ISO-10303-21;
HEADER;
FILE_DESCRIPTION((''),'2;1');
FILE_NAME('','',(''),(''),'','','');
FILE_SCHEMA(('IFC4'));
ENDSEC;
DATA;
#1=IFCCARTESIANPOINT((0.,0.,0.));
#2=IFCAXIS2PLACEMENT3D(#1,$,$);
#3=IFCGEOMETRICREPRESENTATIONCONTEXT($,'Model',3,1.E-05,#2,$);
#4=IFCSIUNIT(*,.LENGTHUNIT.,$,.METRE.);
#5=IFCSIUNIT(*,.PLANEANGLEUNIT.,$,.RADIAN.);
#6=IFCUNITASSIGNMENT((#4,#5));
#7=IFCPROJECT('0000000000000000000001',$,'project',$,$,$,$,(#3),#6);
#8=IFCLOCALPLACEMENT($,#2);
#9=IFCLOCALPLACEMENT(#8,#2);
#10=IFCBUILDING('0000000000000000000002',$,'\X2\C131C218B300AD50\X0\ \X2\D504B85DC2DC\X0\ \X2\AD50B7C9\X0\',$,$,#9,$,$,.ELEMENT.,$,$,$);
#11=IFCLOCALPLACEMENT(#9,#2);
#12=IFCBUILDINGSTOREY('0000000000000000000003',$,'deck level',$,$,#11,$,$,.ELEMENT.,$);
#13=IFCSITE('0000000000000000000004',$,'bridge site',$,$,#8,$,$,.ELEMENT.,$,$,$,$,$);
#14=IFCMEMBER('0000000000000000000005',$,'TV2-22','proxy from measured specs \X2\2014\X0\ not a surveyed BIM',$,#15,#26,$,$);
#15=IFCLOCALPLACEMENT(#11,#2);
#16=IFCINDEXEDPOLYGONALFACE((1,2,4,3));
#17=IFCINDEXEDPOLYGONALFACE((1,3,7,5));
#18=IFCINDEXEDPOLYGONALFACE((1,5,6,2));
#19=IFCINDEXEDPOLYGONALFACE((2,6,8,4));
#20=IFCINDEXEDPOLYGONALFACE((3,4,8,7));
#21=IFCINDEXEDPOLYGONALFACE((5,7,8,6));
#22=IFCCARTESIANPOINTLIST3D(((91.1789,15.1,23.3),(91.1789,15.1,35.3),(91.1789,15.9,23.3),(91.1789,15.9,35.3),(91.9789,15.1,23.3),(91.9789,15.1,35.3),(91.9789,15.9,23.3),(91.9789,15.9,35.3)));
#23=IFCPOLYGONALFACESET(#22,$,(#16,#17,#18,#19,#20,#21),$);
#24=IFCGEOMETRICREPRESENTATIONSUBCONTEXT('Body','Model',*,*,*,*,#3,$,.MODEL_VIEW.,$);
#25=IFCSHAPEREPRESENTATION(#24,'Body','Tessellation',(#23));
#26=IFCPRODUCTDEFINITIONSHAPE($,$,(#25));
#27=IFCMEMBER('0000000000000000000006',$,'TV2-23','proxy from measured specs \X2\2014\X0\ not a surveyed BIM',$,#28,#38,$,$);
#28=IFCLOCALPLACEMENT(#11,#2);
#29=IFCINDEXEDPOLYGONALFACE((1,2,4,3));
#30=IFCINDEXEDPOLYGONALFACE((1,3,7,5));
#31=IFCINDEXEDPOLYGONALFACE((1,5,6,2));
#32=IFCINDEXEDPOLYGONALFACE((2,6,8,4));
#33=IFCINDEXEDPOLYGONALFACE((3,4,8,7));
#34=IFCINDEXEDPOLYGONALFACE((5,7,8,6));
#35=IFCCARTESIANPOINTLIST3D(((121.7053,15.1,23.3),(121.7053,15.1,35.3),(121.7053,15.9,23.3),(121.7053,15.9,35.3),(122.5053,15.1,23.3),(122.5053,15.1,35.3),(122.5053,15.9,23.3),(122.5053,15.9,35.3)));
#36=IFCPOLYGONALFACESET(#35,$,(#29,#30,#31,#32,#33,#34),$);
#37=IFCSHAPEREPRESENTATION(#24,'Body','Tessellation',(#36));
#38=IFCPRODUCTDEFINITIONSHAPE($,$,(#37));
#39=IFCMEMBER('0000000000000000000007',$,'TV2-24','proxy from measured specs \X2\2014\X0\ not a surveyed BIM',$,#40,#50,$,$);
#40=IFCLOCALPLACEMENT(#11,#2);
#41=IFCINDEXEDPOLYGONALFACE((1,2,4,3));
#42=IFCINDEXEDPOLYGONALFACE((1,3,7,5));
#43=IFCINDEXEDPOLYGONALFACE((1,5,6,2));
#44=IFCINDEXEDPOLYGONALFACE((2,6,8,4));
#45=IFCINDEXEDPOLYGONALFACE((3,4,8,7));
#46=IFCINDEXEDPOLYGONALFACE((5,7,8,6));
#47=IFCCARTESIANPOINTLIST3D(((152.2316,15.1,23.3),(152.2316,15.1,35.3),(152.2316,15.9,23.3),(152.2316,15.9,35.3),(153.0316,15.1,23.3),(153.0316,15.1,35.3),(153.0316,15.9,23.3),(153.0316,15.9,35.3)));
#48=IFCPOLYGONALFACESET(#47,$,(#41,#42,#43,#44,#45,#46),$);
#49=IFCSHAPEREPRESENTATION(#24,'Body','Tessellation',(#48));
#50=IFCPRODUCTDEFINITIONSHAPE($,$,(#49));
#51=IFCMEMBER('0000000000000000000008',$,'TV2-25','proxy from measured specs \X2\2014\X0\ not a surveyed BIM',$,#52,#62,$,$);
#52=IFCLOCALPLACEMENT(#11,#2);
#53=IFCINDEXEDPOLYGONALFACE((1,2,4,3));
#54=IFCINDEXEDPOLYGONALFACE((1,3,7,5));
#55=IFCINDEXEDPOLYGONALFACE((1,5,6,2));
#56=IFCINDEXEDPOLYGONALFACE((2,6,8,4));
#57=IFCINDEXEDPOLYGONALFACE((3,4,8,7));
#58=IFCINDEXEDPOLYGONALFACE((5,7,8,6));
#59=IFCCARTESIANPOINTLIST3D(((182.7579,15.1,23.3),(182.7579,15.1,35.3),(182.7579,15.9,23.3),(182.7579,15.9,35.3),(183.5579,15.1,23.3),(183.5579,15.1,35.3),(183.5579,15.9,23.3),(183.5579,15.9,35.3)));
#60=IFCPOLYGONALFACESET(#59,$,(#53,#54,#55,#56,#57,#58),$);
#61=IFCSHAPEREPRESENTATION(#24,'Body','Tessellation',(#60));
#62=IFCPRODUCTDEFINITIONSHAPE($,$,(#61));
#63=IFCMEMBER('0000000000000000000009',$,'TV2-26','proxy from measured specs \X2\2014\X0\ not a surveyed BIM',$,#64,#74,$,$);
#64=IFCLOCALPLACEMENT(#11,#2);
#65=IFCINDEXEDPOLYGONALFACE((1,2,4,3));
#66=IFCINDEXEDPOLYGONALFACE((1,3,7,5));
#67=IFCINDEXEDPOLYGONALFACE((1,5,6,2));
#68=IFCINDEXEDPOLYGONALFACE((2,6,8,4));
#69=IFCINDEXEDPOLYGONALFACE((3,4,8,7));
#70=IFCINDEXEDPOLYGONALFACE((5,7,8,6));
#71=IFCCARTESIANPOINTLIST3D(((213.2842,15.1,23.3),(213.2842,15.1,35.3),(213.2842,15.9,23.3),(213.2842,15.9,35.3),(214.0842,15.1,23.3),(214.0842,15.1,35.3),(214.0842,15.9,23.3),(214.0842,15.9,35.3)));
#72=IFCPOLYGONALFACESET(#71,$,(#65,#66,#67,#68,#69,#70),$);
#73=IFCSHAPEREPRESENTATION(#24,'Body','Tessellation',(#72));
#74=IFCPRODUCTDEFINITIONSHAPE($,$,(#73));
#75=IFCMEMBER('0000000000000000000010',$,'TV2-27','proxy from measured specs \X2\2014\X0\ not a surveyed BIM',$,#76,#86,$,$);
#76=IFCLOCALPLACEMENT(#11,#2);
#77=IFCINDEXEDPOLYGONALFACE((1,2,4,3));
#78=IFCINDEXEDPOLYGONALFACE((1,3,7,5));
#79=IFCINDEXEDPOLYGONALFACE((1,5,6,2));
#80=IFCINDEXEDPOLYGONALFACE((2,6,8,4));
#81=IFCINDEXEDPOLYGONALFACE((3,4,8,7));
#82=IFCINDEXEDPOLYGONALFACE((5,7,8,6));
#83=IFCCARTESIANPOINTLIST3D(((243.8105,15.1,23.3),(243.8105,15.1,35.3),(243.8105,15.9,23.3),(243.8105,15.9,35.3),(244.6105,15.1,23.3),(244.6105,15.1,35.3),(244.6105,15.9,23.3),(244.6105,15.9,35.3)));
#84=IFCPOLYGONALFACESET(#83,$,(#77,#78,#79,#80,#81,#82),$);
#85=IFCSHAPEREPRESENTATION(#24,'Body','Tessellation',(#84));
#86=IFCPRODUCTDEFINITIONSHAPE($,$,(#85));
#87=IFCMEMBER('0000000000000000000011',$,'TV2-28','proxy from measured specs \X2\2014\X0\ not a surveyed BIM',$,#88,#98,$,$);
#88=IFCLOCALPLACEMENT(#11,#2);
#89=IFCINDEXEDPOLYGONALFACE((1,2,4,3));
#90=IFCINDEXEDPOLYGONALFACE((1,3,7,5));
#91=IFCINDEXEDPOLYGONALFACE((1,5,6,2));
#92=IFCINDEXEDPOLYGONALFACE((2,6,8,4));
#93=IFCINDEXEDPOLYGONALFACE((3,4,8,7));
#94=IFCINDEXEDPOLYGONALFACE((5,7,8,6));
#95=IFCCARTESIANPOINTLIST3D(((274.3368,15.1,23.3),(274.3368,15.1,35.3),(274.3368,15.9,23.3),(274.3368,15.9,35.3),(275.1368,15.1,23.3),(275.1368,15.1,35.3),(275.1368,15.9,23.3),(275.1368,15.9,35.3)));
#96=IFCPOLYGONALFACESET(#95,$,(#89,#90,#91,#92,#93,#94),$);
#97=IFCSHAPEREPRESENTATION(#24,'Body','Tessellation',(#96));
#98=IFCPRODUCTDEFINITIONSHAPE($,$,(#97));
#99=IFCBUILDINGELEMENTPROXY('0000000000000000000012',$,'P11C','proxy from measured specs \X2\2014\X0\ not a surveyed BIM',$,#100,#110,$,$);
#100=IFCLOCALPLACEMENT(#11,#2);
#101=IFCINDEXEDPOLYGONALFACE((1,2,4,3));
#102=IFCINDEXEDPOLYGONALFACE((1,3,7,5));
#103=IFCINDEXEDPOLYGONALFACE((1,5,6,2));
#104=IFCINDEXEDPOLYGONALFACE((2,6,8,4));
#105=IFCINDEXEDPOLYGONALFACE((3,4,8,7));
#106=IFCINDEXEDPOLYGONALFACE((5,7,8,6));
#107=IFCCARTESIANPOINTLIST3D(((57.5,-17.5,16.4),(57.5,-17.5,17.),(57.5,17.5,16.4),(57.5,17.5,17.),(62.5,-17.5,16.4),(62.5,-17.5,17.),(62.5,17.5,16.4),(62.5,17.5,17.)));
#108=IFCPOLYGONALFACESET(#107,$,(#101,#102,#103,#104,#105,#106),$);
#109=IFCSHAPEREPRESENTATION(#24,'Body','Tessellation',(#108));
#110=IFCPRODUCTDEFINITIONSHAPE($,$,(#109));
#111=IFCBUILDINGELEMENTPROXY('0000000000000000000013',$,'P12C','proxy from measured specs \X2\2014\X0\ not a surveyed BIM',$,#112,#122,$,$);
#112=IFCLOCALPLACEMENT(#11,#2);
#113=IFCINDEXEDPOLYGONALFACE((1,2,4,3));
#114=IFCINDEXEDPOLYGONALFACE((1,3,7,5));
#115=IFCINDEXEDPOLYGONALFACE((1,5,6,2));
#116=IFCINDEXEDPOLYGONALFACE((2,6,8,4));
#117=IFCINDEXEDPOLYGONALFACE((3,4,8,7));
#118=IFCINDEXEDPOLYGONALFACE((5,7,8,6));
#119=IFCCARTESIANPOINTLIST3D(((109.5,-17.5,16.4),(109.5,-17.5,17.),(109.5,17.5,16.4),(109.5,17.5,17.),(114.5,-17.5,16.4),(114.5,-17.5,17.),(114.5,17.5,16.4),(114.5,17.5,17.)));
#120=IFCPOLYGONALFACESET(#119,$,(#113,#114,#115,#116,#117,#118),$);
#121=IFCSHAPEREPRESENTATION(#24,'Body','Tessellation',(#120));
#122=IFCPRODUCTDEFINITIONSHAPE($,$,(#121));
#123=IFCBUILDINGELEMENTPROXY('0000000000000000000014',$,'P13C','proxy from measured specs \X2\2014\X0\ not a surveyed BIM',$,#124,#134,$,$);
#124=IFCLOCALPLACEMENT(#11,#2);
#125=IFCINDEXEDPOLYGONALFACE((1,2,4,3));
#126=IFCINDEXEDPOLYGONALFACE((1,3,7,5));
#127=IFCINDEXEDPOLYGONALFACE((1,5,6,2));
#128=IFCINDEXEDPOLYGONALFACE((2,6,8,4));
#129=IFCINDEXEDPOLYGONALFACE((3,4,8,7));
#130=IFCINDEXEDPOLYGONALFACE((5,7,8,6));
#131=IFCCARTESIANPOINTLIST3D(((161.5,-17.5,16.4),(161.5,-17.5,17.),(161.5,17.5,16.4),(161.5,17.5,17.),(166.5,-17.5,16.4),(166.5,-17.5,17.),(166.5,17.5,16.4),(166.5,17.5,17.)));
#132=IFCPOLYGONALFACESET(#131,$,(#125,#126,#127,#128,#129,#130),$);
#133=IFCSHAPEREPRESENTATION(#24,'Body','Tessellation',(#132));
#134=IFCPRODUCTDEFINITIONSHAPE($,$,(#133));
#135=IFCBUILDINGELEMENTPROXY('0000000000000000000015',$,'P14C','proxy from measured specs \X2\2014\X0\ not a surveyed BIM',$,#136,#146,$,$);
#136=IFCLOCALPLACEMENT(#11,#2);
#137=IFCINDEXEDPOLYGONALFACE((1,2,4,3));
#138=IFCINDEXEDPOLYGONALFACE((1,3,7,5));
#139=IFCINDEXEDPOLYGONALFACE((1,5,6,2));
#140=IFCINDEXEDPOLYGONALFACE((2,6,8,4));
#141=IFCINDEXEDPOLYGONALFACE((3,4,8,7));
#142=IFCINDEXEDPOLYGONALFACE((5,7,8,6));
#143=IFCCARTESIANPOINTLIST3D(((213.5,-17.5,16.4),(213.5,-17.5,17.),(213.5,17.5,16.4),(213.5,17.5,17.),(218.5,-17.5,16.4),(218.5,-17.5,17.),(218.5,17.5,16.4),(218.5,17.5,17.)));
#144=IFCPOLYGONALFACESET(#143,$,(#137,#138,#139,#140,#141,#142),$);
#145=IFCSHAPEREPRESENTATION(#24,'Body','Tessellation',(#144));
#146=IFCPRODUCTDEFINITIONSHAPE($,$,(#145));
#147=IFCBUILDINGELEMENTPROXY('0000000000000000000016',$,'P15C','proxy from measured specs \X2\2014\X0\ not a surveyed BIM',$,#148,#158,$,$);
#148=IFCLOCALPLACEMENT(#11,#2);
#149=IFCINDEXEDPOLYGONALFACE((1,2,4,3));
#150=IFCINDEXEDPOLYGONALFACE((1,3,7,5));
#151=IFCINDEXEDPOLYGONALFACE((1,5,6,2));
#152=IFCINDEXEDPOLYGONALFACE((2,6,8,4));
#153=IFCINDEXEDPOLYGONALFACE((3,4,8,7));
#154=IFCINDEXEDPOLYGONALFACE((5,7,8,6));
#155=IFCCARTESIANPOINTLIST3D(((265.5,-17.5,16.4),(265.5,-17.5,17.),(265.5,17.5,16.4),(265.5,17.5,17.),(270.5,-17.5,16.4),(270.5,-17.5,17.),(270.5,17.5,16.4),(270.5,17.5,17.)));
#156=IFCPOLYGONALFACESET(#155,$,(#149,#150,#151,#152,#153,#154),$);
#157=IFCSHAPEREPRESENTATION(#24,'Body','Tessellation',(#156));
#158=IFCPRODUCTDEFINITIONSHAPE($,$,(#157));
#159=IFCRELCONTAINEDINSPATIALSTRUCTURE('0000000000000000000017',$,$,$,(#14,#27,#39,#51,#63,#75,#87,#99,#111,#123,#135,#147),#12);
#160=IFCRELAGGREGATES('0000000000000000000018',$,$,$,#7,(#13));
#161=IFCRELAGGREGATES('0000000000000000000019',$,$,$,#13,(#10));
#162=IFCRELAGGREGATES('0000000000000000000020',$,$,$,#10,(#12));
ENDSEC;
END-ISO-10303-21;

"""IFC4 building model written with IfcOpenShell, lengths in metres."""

from ifc_helpers import new_model, si_unit, frame, origin, origin_2d, place, context, subcontext, project, spatial, rectangle, extrude, element, save


model = new_model("IFC4")

# Units and contexts
model_context = context("Model", 3, precision=1e-05, world=origin())
body_context = subcontext(model_context, "Body", "Model", "MODEL_VIEW")
ifc_project = project(units=[si_unit("LENGTHUNIT", "METRE"), si_unit("PLANEANGLEUNIT", "RADIAN")], contexts=[model_context])

# Site, building, storey
site_placement = place(None, origin())
site = spatial("IfcSite", under=ifc_project, at=site_placement, Name="bridge site", CompositionType="ELEMENT")
building_placement = place(site_placement, origin())
building = spatial("IfcBuilding", under=site, at=building_placement, Name="성수대교 프록시 교량", CompositionType="ELEMENT")
storey_placement = place(building_placement, origin())
storey = spatial("IfcBuildingStorey", under=building, at=storey_placement, Name="deck level", CompositionType="ELEMENT")

# Members
for number, where, name in (
    (1, (91.5789, 15.5, 23.3), "TV2-22"),
    (2, (122.1053, 15.5, 23.3), "TV2-23"),
    (3, (152.6316, 15.5, 23.3), "TV2-24"),
    (4, (183.1579, 15.5, 23.3), "TV2-25"),
    (5, (213.6842, 15.5, 23.3), "TV2-26"),
    (6, (244.2105, 15.5, 23.3), "TV2-27"),
):
    element("IfcMember", number, at=place(storey_placement, frame(where)), inside=storey, Name=name, Description="proxy from measured specs — not a surveyed BIM", context=body_context, shape_type="SweptSolid", body=[
        extrude(rectangle(XDim=0.8, YDim=0.8, at=origin_2d()), origin(), (0.0, 0.0, 1.0), 12.0),
    ])
member_1_placement = place(storey_placement, frame((274.7368, 15.5, 23.3)))
element("IfcMember", 7, at=member_1_placement, inside=storey, Name="TV2-28", Description="proxy from measured specs — not a surveyed BIM", context=body_context, shape_type="SweptSolid", body=[
    extrude(rectangle(XDim=0.8, YDim=0.8, at=origin_2d()), origin(), (0.0, 0.0, 1.0), 12.0),
])

# Building element proxies
for number, where, name in (
    (8, (60.0, 0.0, 16.4), "P11C"),
    (9, (112.0, 0.0, 16.4), "P12C"),
    (10, (164.0, 0.0, 16.4), "P13C"),
    (11, (216.0, 0.0, 16.4), "P14C"),
    (12, (268.0, 0.0, 16.4), "P15C"),
):
    element("IfcBuildingElementProxy", number, at=place(storey_placement, frame(where)), inside=storey, Name=name, Description="proxy from measured specs — not a surveyed BIM", context=body_context, shape_type="SweptSolid", body=[
        extrude(rectangle(XDim=5.0, YDim=35.0, at=origin_2d()), origin(), (0.0, 0.0, 1.0), 0.6),
    ])

save(model, "model.ifc")
